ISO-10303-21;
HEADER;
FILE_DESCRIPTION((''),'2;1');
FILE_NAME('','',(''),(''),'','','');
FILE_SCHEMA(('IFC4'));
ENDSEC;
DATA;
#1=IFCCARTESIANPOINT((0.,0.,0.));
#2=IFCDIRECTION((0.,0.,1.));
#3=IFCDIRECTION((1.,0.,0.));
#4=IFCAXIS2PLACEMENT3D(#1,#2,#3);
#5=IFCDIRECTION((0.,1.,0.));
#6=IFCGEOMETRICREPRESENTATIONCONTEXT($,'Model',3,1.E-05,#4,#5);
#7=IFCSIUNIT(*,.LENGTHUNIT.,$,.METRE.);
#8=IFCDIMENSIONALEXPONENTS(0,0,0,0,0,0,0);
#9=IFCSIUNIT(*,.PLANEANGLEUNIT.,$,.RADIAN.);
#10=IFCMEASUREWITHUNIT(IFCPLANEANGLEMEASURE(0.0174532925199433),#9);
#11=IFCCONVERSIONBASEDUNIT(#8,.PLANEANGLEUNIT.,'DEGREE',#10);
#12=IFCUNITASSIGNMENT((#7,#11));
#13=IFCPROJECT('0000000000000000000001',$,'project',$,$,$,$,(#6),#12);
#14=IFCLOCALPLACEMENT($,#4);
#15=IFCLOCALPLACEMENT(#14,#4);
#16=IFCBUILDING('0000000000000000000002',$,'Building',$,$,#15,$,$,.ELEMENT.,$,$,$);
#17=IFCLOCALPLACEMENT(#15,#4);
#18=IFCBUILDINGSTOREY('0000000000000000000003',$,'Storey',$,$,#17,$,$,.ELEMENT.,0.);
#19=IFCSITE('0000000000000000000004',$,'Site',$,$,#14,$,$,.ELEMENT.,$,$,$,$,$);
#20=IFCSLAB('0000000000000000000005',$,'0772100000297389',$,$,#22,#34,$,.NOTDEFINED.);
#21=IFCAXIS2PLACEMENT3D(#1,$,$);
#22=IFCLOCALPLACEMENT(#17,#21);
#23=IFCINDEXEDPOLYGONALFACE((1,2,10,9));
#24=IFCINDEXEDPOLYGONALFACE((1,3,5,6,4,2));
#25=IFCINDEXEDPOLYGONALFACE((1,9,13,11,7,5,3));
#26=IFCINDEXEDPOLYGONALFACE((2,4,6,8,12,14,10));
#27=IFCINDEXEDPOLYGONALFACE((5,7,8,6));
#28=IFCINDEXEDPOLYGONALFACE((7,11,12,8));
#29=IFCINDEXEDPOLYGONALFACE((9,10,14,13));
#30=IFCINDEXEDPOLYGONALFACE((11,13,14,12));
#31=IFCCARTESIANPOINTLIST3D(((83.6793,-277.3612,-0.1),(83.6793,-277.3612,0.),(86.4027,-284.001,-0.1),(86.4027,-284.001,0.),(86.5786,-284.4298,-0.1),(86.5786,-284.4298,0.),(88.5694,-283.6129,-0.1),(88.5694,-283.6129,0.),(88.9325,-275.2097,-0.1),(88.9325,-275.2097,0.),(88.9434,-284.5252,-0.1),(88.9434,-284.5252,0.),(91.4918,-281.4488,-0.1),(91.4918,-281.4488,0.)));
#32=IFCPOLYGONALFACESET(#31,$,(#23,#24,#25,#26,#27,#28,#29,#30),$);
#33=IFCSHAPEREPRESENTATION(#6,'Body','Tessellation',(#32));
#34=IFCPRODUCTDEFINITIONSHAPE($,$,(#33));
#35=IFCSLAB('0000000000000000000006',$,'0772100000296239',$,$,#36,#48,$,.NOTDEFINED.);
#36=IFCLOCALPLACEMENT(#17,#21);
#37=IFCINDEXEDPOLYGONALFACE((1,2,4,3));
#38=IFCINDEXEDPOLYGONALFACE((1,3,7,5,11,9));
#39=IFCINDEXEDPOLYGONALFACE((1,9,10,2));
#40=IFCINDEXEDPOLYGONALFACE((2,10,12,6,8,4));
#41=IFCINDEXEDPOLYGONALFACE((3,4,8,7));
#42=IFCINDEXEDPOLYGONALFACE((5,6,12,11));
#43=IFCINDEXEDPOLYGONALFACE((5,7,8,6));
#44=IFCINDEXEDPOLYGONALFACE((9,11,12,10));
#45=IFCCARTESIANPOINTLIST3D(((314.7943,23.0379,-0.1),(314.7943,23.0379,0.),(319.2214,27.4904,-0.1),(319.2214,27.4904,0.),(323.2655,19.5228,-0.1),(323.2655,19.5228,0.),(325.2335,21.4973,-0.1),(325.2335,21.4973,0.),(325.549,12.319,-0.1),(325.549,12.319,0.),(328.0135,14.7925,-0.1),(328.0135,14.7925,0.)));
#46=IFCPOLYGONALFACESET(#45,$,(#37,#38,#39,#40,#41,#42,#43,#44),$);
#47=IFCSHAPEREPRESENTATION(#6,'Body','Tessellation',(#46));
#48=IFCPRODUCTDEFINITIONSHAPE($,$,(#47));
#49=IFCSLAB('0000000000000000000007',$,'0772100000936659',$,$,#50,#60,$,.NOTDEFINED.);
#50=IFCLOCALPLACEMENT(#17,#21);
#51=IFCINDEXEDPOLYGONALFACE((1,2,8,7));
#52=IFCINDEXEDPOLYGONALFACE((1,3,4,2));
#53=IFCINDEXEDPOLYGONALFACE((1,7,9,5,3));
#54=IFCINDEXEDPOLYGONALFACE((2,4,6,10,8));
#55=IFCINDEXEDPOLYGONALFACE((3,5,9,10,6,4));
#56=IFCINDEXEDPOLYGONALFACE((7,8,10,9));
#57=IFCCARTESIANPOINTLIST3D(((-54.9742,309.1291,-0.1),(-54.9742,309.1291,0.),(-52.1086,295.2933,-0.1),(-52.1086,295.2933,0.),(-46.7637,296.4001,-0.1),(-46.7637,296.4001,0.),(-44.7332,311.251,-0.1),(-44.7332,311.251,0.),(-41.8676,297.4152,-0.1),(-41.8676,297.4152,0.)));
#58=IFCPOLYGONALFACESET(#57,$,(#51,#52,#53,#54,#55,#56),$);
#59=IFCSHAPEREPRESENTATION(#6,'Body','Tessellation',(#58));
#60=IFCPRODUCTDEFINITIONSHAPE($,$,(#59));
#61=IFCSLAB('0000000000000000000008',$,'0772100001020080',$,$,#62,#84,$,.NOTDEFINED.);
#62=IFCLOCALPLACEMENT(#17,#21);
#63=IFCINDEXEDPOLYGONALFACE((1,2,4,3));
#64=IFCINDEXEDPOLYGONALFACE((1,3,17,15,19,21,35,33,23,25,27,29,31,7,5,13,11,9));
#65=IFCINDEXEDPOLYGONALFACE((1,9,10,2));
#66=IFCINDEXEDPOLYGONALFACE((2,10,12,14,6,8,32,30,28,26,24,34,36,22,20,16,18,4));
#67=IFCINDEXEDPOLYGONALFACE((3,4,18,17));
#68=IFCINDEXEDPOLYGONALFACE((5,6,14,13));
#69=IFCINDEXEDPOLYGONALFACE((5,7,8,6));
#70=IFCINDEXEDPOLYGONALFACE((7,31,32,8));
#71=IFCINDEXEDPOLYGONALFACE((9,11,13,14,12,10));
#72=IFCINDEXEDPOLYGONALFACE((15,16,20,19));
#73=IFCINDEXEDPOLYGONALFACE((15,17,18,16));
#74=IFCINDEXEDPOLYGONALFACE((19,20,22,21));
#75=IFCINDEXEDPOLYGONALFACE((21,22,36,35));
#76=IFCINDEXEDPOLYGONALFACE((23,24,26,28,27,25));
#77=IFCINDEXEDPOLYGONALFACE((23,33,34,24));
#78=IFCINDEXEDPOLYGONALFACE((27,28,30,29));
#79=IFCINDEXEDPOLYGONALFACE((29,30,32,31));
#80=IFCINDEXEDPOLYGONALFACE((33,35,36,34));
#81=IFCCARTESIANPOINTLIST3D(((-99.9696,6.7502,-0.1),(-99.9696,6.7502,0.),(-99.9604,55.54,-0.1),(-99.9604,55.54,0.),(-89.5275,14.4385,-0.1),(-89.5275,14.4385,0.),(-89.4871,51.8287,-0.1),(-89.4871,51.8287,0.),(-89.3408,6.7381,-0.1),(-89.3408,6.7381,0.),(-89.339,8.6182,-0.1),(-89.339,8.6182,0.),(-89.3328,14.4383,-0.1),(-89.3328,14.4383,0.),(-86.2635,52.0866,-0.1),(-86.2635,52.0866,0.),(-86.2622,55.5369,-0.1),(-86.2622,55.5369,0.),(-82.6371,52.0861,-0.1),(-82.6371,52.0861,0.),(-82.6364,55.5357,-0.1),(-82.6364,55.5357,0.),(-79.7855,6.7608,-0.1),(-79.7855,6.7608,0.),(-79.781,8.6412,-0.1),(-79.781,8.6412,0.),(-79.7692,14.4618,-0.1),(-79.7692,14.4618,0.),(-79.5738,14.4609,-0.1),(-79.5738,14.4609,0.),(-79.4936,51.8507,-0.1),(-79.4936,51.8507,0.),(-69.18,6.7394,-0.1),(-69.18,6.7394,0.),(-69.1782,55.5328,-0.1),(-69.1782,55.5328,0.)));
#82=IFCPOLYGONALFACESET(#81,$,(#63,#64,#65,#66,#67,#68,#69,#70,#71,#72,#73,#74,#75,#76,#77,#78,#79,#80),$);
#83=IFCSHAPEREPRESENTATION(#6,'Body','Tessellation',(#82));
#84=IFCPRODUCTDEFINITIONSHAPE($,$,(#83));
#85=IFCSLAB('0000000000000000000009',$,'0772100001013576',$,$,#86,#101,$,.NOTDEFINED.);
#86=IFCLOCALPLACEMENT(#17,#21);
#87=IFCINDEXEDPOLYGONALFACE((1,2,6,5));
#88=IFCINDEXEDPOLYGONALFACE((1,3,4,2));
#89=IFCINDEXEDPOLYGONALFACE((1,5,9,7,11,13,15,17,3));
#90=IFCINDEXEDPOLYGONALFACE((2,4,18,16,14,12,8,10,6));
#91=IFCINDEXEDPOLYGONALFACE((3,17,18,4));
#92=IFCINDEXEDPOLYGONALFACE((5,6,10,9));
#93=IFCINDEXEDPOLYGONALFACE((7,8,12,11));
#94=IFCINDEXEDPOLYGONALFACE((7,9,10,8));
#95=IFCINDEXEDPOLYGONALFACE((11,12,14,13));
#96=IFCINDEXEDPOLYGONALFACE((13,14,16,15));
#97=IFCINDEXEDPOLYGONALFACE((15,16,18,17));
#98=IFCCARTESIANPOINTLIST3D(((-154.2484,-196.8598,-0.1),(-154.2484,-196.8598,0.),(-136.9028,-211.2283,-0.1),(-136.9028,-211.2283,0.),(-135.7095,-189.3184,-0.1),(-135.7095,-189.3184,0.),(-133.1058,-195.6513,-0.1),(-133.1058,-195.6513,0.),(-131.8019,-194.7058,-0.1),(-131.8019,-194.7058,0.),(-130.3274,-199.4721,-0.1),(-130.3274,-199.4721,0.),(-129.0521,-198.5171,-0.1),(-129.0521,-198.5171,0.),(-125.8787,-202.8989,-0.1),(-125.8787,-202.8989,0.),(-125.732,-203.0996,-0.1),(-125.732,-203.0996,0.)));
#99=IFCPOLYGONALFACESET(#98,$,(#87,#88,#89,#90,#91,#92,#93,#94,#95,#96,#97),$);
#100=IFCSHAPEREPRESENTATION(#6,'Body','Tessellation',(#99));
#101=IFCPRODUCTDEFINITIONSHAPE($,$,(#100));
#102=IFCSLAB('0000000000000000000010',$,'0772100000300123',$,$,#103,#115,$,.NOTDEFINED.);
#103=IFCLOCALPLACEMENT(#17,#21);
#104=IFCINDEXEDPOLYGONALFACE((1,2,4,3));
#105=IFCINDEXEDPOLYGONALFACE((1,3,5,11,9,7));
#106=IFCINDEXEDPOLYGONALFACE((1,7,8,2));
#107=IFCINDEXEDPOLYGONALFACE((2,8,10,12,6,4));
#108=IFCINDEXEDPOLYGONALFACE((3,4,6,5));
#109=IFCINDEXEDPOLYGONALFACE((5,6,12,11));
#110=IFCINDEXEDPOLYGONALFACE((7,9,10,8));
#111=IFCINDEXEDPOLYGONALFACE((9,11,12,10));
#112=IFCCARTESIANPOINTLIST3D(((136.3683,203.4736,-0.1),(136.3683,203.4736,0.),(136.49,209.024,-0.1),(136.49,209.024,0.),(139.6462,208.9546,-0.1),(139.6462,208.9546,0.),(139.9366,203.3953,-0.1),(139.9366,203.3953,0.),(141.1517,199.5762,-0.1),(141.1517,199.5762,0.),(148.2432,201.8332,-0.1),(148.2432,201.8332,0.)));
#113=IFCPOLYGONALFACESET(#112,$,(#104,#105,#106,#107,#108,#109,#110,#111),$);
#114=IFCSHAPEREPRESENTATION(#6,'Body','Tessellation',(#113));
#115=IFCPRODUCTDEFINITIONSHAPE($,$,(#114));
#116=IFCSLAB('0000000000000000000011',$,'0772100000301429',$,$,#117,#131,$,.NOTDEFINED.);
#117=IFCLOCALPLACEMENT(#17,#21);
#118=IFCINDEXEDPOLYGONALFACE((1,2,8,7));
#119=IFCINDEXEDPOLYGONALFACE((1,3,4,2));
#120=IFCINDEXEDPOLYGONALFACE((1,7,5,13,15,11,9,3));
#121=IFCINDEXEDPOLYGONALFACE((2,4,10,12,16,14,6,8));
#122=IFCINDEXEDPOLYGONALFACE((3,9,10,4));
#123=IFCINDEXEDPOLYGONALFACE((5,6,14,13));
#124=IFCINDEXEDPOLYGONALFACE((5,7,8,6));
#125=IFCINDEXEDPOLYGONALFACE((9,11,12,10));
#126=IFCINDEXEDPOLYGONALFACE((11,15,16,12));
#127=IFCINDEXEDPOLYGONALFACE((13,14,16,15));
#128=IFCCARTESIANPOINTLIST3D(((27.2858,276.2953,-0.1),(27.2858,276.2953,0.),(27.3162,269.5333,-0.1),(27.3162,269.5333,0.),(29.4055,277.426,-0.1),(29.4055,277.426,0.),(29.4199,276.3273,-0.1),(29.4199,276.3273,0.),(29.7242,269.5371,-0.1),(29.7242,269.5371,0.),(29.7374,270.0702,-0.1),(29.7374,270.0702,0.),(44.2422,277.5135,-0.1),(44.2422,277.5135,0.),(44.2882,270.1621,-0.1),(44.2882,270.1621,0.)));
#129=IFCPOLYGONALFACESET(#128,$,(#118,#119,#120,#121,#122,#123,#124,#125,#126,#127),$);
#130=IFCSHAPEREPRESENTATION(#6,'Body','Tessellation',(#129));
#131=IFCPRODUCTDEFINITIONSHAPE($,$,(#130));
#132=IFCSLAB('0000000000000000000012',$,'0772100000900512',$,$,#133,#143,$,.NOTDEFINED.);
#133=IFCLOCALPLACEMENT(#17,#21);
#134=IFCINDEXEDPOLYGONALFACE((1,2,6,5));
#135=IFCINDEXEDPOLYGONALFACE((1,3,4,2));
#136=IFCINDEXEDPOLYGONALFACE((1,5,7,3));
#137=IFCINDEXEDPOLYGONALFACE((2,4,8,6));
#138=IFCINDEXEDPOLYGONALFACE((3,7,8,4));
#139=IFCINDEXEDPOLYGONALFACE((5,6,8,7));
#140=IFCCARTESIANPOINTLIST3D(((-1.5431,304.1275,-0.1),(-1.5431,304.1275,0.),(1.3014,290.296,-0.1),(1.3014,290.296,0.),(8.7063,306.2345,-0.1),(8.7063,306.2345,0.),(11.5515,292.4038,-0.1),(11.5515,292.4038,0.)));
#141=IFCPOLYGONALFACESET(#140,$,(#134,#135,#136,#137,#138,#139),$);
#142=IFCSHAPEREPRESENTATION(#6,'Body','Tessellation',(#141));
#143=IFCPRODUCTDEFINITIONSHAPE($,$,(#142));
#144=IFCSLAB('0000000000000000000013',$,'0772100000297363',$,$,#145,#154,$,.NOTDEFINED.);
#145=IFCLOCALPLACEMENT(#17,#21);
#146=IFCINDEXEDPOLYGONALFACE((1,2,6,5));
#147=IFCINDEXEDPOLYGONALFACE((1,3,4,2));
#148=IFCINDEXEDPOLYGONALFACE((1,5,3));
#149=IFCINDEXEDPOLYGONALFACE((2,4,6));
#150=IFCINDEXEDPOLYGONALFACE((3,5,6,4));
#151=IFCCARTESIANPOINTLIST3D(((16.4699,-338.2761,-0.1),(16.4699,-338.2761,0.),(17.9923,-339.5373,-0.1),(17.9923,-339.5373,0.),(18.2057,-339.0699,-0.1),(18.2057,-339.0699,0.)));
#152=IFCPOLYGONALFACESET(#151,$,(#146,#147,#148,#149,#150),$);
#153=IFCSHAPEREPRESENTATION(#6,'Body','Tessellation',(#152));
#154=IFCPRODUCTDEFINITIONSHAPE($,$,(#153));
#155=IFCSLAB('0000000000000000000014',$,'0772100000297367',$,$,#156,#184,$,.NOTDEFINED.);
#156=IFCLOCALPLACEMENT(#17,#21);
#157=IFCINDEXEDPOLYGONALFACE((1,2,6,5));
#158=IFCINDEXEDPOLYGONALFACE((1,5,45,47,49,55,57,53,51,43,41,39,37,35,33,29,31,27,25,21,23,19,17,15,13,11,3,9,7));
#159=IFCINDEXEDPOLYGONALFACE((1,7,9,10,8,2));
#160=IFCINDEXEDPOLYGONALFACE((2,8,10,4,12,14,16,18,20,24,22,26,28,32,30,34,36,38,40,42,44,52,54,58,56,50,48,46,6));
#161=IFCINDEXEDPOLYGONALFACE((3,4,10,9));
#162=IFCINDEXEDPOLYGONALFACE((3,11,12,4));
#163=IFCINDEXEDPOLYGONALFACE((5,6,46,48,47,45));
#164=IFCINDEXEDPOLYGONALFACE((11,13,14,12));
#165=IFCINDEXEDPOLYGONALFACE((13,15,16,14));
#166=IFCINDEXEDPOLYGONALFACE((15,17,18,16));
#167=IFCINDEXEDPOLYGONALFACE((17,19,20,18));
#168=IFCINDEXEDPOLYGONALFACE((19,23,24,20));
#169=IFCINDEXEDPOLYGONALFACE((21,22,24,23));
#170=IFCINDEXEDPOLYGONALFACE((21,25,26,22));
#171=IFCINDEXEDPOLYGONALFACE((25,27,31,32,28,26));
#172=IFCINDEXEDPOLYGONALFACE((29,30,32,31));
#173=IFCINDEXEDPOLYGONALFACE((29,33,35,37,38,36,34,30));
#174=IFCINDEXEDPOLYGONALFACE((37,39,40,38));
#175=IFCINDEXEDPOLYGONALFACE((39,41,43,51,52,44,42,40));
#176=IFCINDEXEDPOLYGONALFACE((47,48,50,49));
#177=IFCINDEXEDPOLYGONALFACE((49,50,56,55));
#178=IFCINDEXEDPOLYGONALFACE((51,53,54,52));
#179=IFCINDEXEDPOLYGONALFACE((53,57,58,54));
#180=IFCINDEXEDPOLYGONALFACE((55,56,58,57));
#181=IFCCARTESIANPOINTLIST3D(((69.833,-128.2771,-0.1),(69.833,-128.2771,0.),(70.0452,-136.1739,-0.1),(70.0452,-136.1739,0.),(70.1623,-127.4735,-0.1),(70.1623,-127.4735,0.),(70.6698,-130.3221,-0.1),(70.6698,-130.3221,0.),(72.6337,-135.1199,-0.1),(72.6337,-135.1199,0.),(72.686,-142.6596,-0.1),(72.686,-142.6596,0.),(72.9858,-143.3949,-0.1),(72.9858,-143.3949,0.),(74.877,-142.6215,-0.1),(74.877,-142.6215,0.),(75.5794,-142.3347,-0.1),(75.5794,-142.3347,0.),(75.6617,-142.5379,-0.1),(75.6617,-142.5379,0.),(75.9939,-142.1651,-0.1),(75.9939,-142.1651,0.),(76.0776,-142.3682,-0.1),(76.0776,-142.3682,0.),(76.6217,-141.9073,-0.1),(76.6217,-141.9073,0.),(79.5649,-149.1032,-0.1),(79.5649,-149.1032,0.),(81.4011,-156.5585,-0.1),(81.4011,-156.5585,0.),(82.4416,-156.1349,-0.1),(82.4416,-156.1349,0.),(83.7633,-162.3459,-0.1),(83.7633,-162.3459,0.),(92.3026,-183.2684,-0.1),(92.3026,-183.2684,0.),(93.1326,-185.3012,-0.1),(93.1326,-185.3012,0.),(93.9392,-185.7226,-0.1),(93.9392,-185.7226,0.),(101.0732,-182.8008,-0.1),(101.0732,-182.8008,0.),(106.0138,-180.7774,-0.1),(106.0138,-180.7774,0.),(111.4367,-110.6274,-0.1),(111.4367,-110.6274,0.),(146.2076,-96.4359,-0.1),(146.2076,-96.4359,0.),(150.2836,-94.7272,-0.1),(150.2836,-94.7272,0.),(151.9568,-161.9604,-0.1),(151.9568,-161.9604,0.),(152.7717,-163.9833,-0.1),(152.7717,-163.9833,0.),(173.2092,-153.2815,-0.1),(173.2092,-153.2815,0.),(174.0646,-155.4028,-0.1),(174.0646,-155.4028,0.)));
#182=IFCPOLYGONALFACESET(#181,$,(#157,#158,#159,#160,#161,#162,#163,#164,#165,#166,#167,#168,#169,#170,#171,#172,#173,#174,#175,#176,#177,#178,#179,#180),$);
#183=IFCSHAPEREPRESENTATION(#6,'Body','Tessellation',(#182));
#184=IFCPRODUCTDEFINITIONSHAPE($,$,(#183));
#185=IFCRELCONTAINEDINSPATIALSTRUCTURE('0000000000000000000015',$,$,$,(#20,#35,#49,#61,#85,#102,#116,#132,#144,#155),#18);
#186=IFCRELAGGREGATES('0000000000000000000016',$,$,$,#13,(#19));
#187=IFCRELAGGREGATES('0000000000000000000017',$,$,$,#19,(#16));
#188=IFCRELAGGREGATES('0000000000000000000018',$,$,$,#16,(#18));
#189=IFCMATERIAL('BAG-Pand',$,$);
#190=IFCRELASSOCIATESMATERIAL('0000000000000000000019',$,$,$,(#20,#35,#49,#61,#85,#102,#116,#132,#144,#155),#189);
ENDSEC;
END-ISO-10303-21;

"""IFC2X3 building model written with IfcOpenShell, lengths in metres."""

from ifc_helpers import new_model, entity, si_unit, converted_unit, direction, frame, origin_with_axes, place, context, project, spatial, polyline, outline, extrude, material, element, save


model = new_model("IFC2X3")

# Units and contexts
model_context = context("Model", 3, precision=1e-05, world=origin_with_axes(), true_north=direction((0.0, 1.0, 0.0)))
ifc_project = project(units=[si_unit("LENGTHUNIT", "METRE"), converted_unit("PLANEANGLEUNIT", "DEGREE", entity("IfcPlaneAngleMeasure", 0.0174532925199433), si_unit("PLANEANGLEUNIT", "RADIAN"), dimensions=[0, 0, 0, 0, 0, 0, 0])], contexts=[model_context])

# Site, building, storey
site_placement = place(None, origin_with_axes())
site = spatial("IfcSite", under=ifc_project, at=site_placement, Name="Site", CompositionType="ELEMENT")
building_placement = place(site_placement, origin_with_axes())
building = spatial("IfcBuilding", under=site, at=building_placement, Name="Building", CompositionType="ELEMENT")
storey_placement = place(building_placement, origin_with_axes())
storey = spatial("IfcBuildingStorey", under=building, at=storey_placement, Name="Storey", CompositionType="ELEMENT", Elevation=0.0)

# Slabs
ifc_material = material(Name="BAG-Pand")
slab_1_placement = place(storey_placement, frame((0.0, 0.0, -0.1), z_axis=(0.0, 0.0, 1.0), x_axis=(1.0, 0.0, 0.0)))
element("IfcSlab", 1, at=slab_1_placement, inside=storey, material=ifc_material, Name="0772100000297389", PredefinedType="NOTDEFINED", context=model_context, shape_type="SweptSolid", body=[
    extrude(outline(polyline([(88.5694, -283.6129), (86.5786, -284.4298), (86.4027, -284.001), (83.6793, -277.3612), (88.9325, -275.2097), (91.4918, -281.4488), (88.9434, -284.5252), (88.5694, -283.6129)])), origin_with_axes(), (0.0, 0.0, 1.0), 0.1),
])
slab_2_placement = place(storey_placement, frame((0.0, 0.0, -0.1), z_axis=(0.0, 0.0, 1.0), x_axis=(1.0, 0.0, 0.0)))
element("IfcSlab", 2, at=slab_2_placement, inside=storey, material=ifc_material, Name="0772100000296239", PredefinedType="NOTDEFINED", context=model_context, shape_type="SweptSolid", body=[
    extrude(outline(polyline([(314.7943, 23.0379), (319.2214, 27.4904), (325.2335, 21.4973), (323.2655, 19.5228), (328.0135, 14.7925), (325.549, 12.319), (314.7943, 23.0379)])), origin_with_axes(), (0.0, 0.0, 1.0), 0.1),
])
slab_3_placement = place(storey_placement, frame((0.0, 0.0, -0.1), z_axis=(0.0, 0.0, 1.0), x_axis=(1.0, 0.0, 0.0)))
element("IfcSlab", 3, at=slab_3_placement, inside=storey, material=ifc_material, Name="0772100000936659", PredefinedType="NOTDEFINED", context=model_context, shape_type="SweptSolid", body=[
    extrude(outline(polyline([(-44.7332, 311.251), (-41.8676, 297.4152), (-46.7637, 296.4001), (-52.1086, 295.2933), (-54.9742, 309.1291), (-44.7332, 311.251)])), origin_with_axes(), (0.0, 0.0, 1.0), 0.1),
])
slab_4_placement = place(storey_placement, frame((0.0, 0.0, -0.1), z_axis=(0.0, 0.0, 1.0), x_axis=(1.0, 0.0, 0.0)))
element("IfcSlab", 4, at=slab_4_placement, inside=storey, material=ifc_material, Name="0772100001020080", PredefinedType="NOTDEFINED", context=model_context, shape_type="SweptSolid", body=[
    extrude(outline(polyline([(-82.6364, 55.5357), (-69.1782, 55.5328), (-69.18, 6.7394), (-79.7855, 6.7608), (-79.781, 8.6412), (-79.7692, 14.4618), (-79.5738, 14.4609), (-79.4936, 51.8507), (-89.4871, 51.8287), (-89.5275, 14.4385), (-89.3328, 14.4383), (-89.339, 8.6182), (-89.3408, 6.7381), (-99.9696, 6.7502), (-99.9604, 55.54), (-86.2622, 55.5369), (-86.2635, 52.0866), (-82.6371, 52.0861), (-82.6364, 55.5357)])), origin_with_axes(), (0.0, 0.0, 1.0), 0.1),
])
slab_5_placement = place(storey_placement, frame((0.0, 0.0, -0.1), z_axis=(0.0, 0.0, 1.0), x_axis=(1.0, 0.0, 0.0)))
element("IfcSlab", 5, at=slab_5_placement, inside=storey, material=ifc_material, Name="0772100001013576", PredefinedType="NOTDEFINED", context=model_context, shape_type="SweptSolid", body=[
    extrude(outline(polyline([(-135.7095, -189.3184), (-131.8019, -194.7058), (-133.1058, -195.6513), (-130.3274, -199.4721), (-129.0521, -198.5171), (-125.8787, -202.8989), (-125.732, -203.0996), (-136.9028, -211.2283), (-154.2484, -196.8598), (-135.7095, -189.3184)])), origin_with_axes(), (0.0, 0.0, 1.0), 0.1),
])
slab_6_placement = place(storey_placement, frame((0.0, 0.0, -0.1), z_axis=(0.0, 0.0, 1.0), x_axis=(1.0, 0.0, 0.0)))
element("IfcSlab", 6, at=slab_6_placement, inside=storey, material=ifc_material, Name="0772100000300123", PredefinedType="NOTDEFINED", context=model_context, shape_type="SweptSolid", body=[
    extrude(outline(polyline([(141.1517, 199.5762), (139.9366, 203.3953), (136.3683, 203.4736), (136.49, 209.024), (139.6462, 208.9546), (148.2432, 201.8332), (141.1517, 199.5762)])), origin_with_axes(), (0.0, 0.0, 1.0), 0.1),
])
slab_7_placement = place(storey_placement, frame((0.0, 0.0, -0.1), z_axis=(0.0, 0.0, 1.0), x_axis=(1.0, 0.0, 0.0)))
element("IfcSlab", 7, at=slab_7_placement, inside=storey, material=ifc_material, Name="0772100000301429", PredefinedType="NOTDEFINED", context=model_context, shape_type="SweptSolid", body=[
    extrude(outline(polyline([(29.7374, 270.0702), (29.7242, 269.5371), (27.3162, 269.5333), (27.2858, 276.2953), (29.4199, 276.3273), (29.4055, 277.426), (44.2422, 277.5135), (44.2882, 270.1621), (29.7374, 270.0702)])), origin_with_axes(), (0.0, 0.0, 1.0), 0.1),
])
slab_8_placement = place(storey_placement, frame((0.0, 0.0, -0.1), z_axis=(0.0, 0.0, 1.0), x_axis=(1.0, 0.0, 0.0)))
element("IfcSlab", 8, at=slab_8_placement, inside=storey, material=ifc_material, Name="0772100000900512", PredefinedType="NOTDEFINED", context=model_context, shape_type="SweptSolid", body=[
    extrude(outline(polyline([(-1.5431, 304.1275), (8.7063, 306.2345), (11.5515, 292.4038), (1.3014, 290.296), (-1.5431, 304.1275)])), origin_with_axes(), (0.0, 0.0, 1.0), 0.1),
])
slab_9_placement = place(storey_placement, frame((0.0, 0.0, -0.1), z_axis=(0.0, 0.0, 1.0), x_axis=(1.0, 0.0, 0.0)))
element("IfcSlab", 9, at=slab_9_placement, inside=storey, material=ifc_material, Name="0772100000297363", PredefinedType="NOTDEFINED", context=model_context, shape_type="SweptSolid", body=[
    extrude(outline(polyline([(18.2057, -339.0699), (17.9923, -339.5373), (16.4699, -338.2761), (18.2057, -339.0699)])), origin_with_axes(), (0.0, 0.0, 1.0), 0.1),
])
slab_10_placement = place(storey_placement, frame((0.0, 0.0, -0.1), z_axis=(0.0, 0.0, 1.0), x_axis=(1.0, 0.0, 0.0)))
element("IfcSlab", 10, at=slab_10_placement, inside=storey, material=ifc_material, Name="0772100000297367", PredefinedType="NOTDEFINED", context=model_context, shape_type="SweptSolid", body=[
    extrude(outline(polyline([(92.3026, -183.2684), (83.7633, -162.3459), (81.4011, -156.5585), (82.4416, -156.1349), (79.5649, -149.1032), (76.6217, -141.9073), (75.9939, -142.1651), (76.0776, -142.3682), (75.6617, -142.5379), (75.5794, -142.3347), (74.877, -142.6215), (72.9858, -143.3949), (72.686, -142.6596), (70.0452, -136.1739), (72.6337, -135.1199), (70.6698, -130.3221), (69.833, -128.2771), (70.1623, -127.4735), (111.4367, -110.6274), (146.2076, -96.4359), (150.2836, -94.7272), (173.2092, -153.2815), (174.0646, -155.4028), (152.7717, -163.9833), (151.9568, -161.9604), (106.0138, -180.7774), (101.0732, -182.8008), (93.9392, -185.7226), (93.1326, -185.3012), (92.3026, -183.2684)])), origin_with_axes(), (0.0, 0.0, 1.0), 0.1),
])

save(model, "model.ifc")
